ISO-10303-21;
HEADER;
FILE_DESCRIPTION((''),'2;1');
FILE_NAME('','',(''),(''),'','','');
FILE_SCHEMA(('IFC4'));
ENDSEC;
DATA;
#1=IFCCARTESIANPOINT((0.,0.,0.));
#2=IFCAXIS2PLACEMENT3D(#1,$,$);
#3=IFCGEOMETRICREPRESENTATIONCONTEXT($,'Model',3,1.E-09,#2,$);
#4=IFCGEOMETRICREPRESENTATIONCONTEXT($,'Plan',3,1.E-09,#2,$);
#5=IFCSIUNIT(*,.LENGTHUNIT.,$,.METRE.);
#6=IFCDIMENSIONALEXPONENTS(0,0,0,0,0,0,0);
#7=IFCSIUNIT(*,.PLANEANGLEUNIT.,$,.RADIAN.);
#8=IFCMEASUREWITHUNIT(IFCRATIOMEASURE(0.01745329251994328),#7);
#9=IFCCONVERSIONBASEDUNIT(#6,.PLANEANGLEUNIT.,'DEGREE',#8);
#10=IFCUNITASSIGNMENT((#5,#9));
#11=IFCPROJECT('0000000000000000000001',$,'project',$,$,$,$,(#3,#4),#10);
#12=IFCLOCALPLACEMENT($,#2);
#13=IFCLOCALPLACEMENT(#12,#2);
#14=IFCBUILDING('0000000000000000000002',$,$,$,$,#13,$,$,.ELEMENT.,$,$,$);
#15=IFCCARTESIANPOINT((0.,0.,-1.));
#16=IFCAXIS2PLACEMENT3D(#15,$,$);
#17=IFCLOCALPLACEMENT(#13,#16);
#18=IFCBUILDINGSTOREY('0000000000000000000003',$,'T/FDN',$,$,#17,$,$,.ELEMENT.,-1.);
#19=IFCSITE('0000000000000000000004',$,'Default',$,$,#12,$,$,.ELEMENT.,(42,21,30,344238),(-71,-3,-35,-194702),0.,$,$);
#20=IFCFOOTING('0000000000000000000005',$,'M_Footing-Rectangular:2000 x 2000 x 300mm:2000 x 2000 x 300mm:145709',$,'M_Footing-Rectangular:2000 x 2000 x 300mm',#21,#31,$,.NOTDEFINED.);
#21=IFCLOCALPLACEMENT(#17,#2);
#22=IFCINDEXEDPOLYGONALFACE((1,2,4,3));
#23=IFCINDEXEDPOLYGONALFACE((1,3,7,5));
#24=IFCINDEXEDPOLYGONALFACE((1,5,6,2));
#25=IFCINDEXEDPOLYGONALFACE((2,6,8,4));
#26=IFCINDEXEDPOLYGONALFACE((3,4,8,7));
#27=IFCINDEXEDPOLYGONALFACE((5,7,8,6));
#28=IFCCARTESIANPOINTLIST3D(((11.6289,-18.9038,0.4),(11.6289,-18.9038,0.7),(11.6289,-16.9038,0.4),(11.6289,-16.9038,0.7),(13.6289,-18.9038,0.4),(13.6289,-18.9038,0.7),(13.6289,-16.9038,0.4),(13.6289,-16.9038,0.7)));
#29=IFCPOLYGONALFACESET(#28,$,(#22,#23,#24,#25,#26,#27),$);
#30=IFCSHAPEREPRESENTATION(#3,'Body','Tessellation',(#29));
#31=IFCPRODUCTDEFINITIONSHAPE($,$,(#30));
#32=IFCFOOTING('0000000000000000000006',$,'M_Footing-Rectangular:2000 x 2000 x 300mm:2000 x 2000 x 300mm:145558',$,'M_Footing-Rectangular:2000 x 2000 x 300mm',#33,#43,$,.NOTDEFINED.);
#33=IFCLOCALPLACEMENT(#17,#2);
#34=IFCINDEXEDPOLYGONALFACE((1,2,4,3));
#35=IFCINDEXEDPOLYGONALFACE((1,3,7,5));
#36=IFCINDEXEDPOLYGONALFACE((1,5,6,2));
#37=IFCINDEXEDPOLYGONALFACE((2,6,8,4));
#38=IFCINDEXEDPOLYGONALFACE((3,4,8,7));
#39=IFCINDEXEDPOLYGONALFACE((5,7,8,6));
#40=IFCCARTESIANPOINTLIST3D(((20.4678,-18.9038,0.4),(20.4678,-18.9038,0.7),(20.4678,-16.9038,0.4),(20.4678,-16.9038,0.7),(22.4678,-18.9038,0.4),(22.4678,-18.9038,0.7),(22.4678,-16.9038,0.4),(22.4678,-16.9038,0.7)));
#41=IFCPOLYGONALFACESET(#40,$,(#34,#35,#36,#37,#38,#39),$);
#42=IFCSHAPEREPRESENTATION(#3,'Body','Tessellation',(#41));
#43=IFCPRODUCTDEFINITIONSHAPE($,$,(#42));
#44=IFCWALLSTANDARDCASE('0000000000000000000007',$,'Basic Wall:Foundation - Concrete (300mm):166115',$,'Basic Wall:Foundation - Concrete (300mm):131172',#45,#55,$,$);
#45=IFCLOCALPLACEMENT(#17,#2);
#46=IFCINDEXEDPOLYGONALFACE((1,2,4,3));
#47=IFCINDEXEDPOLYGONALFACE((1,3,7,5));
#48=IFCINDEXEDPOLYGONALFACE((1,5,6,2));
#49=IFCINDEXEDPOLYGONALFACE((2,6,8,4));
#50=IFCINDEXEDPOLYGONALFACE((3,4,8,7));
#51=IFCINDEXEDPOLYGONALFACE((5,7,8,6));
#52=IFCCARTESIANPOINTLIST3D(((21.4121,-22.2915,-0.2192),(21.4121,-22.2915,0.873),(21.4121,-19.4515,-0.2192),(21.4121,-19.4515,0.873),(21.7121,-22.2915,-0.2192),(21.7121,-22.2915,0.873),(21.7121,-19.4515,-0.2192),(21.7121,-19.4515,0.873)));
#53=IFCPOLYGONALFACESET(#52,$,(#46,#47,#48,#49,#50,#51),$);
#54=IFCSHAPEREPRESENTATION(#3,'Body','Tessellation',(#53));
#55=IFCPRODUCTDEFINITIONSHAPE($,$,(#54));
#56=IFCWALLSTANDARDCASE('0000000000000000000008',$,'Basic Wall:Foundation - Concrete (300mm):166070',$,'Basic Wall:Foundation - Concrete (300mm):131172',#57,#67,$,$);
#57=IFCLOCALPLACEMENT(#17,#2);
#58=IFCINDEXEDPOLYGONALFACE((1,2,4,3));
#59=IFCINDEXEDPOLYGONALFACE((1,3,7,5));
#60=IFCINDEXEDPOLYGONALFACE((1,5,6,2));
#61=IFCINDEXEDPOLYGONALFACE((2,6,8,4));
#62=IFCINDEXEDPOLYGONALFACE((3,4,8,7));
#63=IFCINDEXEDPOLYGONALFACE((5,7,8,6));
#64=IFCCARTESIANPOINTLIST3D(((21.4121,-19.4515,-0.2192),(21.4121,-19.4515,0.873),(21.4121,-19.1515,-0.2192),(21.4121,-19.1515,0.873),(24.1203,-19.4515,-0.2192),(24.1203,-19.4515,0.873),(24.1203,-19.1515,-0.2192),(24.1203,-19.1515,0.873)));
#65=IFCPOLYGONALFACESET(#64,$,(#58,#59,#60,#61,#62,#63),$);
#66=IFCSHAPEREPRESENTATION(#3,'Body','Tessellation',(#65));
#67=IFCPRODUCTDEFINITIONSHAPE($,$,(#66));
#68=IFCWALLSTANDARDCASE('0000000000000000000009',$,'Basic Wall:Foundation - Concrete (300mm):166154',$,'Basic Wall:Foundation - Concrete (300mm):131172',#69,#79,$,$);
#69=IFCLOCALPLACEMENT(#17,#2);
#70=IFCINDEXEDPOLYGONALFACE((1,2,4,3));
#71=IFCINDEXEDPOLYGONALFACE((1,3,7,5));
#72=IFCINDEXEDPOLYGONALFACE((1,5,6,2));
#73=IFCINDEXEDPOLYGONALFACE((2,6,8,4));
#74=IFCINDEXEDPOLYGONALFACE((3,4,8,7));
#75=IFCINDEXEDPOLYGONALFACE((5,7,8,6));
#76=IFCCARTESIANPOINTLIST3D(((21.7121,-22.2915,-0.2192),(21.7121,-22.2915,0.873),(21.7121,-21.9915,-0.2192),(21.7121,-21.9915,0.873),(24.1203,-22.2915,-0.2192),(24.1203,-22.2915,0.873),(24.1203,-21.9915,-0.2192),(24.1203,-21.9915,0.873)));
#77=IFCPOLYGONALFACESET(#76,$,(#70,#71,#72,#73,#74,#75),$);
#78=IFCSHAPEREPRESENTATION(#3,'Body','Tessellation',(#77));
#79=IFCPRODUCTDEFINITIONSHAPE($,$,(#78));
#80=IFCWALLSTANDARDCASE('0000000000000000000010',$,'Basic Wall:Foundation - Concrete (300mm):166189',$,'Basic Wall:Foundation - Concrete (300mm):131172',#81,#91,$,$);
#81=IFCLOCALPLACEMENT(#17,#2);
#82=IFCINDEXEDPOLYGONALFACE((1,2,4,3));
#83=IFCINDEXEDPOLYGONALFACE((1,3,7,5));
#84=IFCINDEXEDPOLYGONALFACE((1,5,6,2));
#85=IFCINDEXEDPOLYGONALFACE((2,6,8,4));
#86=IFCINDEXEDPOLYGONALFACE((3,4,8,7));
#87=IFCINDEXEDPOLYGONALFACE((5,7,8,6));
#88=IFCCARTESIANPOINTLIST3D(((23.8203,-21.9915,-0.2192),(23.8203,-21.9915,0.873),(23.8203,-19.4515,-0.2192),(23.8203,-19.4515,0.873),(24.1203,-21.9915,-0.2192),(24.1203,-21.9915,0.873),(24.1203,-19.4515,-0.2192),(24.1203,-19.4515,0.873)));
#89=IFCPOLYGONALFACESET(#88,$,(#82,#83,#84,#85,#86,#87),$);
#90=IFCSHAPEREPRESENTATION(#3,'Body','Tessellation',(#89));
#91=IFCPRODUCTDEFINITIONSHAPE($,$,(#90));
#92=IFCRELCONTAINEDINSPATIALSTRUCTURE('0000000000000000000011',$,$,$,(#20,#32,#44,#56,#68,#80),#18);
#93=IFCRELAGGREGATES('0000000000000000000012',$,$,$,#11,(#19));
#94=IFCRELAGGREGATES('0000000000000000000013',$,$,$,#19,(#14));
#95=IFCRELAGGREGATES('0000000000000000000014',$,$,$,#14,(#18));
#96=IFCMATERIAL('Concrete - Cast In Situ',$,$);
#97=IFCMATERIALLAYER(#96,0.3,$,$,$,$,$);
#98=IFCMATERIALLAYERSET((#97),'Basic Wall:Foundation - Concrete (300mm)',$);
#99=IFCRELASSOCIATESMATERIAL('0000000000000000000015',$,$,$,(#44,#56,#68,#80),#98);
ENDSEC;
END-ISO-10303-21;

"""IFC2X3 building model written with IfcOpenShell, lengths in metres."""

from ifc_helpers import new_model, entity, si_unit, converted_unit, frame, frame_2d, origin, origin_2d_with_axis, place, context, project, spatial, rectangle, extrude, material, layer, layer_set, layer_usage, element, save


model = new_model("IFC2X3")

# Units and contexts
model_context = context("Model", 3, precision=1e-09, world=origin())
plan_context = context("Plan", 3, precision=1e-09, world=origin())
ifc_project = project(units=[si_unit("LENGTHUNIT", "METRE"), converted_unit("PLANEANGLEUNIT", "DEGREE", entity("IfcRatioMeasure", 0.01745329251994328), si_unit("PLANEANGLEUNIT", "RADIAN"), dimensions=[0, 0, 0, 0, 0, 0, 0])], contexts=[model_context, plan_context])

# Site, building, storey
site_placement = place(None, origin())
site = spatial("IfcSite", under=ifc_project, at=site_placement, Name="Default", CompositionType="ELEMENT", RefLatitude=(42, 21, 30, 344238), RefLongitude=(-71, -3, -35, -194702), RefElevation=0.0)
building_placement = place(site_placement, origin())
building = spatial("IfcBuilding", under=site, at=building_placement, CompositionType="ELEMENT")
storey_placement = place(building_placement, frame((0.0, 0.0, -1.0)))
storey = spatial("IfcBuildingStorey", under=building, at=storey_placement, Name="T/FDN", CompositionType="ELEMENT", Elevation=-1.0)

# Footings
footing_1_placement = place(storey_placement, origin())
element("IfcFooting", 1, at=footing_1_placement, inside=storey, Name="M_Footing-Rectangular:2000 x 2000 x 300mm:2000 x 2000 x 300mm:145709", ObjectType="M_Footing-Rectangular:2000 x 2000 x 300mm", PredefinedType="NOTDEFINED", context=model_context, shape_type="SweptSolid", body=[
    extrude(rectangle(XDim=2.0, YDim=2.0, at=origin_2d_with_axis()), frame((12.6289, -17.9038, 0.4), z_axis=(0.0, 0.0, 1.0), x_axis=(-1.0, 0.0, 0.0)), (0.0, 0.0, 1.0), 0.3),
])
footing_2_placement = place(storey_placement, origin())
element("IfcFooting", 2, at=footing_2_placement, inside=storey, Name="M_Footing-Rectangular:2000 x 2000 x 300mm:2000 x 2000 x 300mm:145558", ObjectType="M_Footing-Rectangular:2000 x 2000 x 300mm", PredefinedType="NOTDEFINED", context=model_context, shape_type="SweptSolid", body=[
    extrude(rectangle(XDim=2.0, YDim=2.0, at=origin_2d_with_axis()), frame((21.4678, -17.9038, 0.4), z_axis=(0.0, 0.0, 1.0), x_axis=(-1.0, 0.0, 0.0)), (0.0, 0.0, 1.0), 0.3),
])

# Walls
ifc_material_1 = material(Name="Concrete - Cast In Situ")
ifc_layer = layer(ifc_material_1, 0.3)
ifc_layer_set = layer_set([ifc_layer], Name="Basic Wall:Foundation - Concrete (300mm)")
ifc_layer_usage = layer_usage(ifc_layer_set, "AXIS2", "NEGATIVE", 0.15)
wall_1_placement = place(storey_placement, frame((21.5621, -19.4515, -0.2192), z_axis=(0.0, 0.0, 1.0), x_axis=(0.0, -1.0, 0.0)))
element("IfcWallStandardCase", 3, at=wall_1_placement, inside=storey, material=ifc_layer_usage, Name="Basic Wall:Foundation - Concrete (300mm):166115", ObjectType="Basic Wall:Foundation - Concrete (300mm):131172", context=model_context, shape_type="SweptSolid", body=[
    extrude(rectangle(XDim=2.84, YDim=0.3, at=frame_2d((1.42, 0.0), x_axis=(-1.0, 0.0))), origin(), (0.0, 0.0, 1.0), 1.0922),
])
wall_2_placement = place(storey_placement, frame((24.1203, -19.3015, -0.2192), z_axis=(0.0, 0.0, 1.0), x_axis=(-1.0, 0.0, 0.0)))
element("IfcWallStandardCase", 4, at=wall_2_placement, inside=storey, material=ifc_layer_usage, Name="Basic Wall:Foundation - Concrete (300mm):166070", ObjectType="Basic Wall:Foundation - Concrete (300mm):131172", context=model_context, shape_type="SweptSolid", body=[
    extrude(rectangle(XDim=2.7082, YDim=0.3, at=frame_2d((1.3541, 0.0), x_axis=(-1.0, 0.0))), origin(), (0.0, 0.0, 1.0), 1.0922),
])
wall_3_placement = place(storey_placement, frame((21.7121, -22.1415, -0.2192)))
element("IfcWallStandardCase", 5, at=wall_3_placement, inside=storey, material=ifc_layer_usage, Name="Basic Wall:Foundation - Concrete (300mm):166154", ObjectType="Basic Wall:Foundation - Concrete (300mm):131172", context=model_context, shape_type="SweptSolid", body=[
    extrude(rectangle(XDim=2.4082, YDim=0.3, at=frame_2d((1.2041, 0.0), x_axis=(-1.0, 0.0))), origin(), (0.0, 0.0, 1.0), 1.0922),
])
wall_4_placement = place(storey_placement, frame((23.9703, -21.9915, -0.2192), z_axis=(0.0, 0.0, 1.0), x_axis=(0.0, 1.0, 0.0)))
element("IfcWallStandardCase", 6, at=wall_4_placement, inside=storey, material=ifc_layer_usage, Name="Basic Wall:Foundation - Concrete (300mm):166189", ObjectType="Basic Wall:Foundation - Concrete (300mm):131172", context=model_context, shape_type="SweptSolid", body=[
    extrude(rectangle(XDim=2.54, YDim=0.3, at=frame_2d((1.27, 0.0), x_axis=(-1.0, 0.0))), origin(), (0.0, 0.0, 1.0), 1.0922),
])

save(model, "model.ifc")
